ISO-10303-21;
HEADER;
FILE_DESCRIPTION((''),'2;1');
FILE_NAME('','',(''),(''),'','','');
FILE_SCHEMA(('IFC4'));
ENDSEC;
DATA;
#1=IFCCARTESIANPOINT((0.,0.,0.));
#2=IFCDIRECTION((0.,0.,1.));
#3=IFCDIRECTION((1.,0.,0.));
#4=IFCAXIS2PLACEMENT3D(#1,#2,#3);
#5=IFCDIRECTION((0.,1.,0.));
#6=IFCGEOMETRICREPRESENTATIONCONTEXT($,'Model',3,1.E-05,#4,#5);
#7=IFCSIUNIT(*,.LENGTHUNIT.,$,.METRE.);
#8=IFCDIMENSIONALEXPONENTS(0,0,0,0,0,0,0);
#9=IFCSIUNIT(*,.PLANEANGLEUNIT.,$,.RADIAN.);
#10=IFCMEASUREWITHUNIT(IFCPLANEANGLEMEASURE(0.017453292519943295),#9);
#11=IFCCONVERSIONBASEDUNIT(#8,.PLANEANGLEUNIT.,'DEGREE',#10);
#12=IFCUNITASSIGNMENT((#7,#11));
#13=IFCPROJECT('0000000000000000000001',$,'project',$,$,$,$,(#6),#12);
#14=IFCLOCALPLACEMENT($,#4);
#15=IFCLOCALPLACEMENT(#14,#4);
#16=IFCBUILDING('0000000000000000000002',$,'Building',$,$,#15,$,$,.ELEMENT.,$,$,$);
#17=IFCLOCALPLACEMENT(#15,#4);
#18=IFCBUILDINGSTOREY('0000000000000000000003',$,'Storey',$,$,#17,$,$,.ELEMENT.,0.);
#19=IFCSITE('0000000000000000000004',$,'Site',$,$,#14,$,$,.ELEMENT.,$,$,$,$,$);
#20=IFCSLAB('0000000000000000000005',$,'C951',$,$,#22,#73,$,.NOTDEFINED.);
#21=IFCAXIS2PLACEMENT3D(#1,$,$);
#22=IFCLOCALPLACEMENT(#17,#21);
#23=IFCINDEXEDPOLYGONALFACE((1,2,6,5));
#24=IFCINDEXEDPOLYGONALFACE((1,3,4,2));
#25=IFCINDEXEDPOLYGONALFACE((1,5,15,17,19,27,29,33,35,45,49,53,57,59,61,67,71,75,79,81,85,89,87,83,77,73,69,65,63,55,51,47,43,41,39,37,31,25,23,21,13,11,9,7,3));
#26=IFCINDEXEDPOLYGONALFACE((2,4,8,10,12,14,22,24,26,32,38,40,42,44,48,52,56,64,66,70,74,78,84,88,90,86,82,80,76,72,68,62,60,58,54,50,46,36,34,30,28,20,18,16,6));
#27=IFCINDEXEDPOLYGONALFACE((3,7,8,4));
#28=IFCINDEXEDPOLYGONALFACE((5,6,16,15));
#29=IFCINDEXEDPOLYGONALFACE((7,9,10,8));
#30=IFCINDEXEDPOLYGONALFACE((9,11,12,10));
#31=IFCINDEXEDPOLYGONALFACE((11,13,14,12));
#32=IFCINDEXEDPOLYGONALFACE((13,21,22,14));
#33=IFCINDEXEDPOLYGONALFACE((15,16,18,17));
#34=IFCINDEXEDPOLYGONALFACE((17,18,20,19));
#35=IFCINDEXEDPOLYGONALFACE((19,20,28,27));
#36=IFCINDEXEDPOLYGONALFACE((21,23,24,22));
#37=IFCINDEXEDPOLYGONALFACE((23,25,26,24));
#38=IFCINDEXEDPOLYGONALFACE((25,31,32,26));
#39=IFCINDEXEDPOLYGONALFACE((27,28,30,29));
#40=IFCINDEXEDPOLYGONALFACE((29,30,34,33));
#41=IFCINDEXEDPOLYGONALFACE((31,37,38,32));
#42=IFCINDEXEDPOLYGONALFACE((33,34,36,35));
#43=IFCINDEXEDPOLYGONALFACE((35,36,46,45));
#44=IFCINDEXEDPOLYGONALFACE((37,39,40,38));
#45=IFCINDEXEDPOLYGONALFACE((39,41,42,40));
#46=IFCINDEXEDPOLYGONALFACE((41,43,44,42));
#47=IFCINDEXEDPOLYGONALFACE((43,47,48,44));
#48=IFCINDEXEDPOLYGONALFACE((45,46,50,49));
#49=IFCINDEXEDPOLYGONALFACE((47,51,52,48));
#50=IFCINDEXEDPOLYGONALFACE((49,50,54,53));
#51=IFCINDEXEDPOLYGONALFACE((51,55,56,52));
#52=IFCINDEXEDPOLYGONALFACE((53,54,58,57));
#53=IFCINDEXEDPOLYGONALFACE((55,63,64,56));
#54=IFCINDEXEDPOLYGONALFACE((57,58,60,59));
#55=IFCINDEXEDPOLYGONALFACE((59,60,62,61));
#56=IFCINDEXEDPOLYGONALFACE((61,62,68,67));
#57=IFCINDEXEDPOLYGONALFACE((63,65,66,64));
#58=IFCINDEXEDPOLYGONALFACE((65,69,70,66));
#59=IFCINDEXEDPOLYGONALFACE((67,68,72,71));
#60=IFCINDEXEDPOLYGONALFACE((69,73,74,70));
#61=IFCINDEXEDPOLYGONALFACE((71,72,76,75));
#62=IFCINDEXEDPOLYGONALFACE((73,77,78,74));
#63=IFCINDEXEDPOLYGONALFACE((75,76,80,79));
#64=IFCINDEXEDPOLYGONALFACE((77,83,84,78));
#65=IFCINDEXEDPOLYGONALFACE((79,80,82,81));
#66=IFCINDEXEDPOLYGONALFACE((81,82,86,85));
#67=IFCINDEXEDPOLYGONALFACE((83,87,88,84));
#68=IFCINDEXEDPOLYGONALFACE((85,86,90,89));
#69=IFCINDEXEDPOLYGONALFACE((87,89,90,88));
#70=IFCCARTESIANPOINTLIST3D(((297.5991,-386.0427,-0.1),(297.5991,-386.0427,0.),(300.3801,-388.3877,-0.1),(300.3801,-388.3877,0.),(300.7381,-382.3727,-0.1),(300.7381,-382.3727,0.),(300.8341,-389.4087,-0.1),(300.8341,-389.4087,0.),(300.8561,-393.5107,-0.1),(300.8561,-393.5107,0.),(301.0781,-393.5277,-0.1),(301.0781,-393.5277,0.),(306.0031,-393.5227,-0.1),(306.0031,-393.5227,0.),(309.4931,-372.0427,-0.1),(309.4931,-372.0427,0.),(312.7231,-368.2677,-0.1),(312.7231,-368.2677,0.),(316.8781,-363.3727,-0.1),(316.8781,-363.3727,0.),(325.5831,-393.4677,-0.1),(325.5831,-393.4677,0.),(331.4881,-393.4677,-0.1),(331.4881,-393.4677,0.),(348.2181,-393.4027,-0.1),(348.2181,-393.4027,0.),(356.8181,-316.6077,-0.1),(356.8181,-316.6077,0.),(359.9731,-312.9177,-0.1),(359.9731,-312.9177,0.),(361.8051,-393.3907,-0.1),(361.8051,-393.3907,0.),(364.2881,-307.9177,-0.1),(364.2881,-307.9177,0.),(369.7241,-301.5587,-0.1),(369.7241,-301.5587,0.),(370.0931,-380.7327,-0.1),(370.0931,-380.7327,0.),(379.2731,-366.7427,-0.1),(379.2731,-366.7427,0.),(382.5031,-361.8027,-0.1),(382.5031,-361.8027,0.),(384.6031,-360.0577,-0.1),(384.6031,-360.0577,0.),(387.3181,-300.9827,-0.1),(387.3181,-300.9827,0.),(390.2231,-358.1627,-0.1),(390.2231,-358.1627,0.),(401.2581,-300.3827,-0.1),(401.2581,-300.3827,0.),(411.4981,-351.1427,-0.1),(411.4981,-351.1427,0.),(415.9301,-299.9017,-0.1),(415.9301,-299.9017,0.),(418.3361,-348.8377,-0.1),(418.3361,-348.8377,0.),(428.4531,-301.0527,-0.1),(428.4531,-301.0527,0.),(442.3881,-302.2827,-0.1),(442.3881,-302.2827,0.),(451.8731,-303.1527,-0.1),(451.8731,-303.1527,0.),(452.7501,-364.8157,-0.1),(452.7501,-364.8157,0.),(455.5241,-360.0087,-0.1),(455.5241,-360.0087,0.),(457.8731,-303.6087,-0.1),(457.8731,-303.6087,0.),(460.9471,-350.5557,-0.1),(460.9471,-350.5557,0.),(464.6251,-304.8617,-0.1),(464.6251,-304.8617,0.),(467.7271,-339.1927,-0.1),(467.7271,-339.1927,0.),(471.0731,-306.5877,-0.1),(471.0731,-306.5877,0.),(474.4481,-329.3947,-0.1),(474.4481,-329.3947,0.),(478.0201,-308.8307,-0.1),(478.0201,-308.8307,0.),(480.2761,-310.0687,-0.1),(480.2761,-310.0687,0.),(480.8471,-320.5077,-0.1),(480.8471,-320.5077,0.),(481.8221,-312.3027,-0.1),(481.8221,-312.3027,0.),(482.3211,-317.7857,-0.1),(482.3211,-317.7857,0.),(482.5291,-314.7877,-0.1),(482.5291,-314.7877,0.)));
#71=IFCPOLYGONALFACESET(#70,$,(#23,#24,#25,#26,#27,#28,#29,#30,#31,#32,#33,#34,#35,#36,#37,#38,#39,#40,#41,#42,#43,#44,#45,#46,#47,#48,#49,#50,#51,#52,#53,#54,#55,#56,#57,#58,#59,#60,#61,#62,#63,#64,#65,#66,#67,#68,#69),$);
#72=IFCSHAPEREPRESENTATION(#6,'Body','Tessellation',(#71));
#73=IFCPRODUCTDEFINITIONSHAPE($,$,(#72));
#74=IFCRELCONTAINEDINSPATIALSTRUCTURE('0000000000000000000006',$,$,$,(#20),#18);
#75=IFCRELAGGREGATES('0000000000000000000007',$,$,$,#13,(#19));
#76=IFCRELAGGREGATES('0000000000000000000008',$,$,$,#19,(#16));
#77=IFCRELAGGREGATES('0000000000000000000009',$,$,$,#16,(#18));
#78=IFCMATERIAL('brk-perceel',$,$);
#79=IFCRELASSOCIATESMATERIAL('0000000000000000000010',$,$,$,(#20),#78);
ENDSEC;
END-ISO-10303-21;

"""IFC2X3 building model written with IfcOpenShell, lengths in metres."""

from ifc_helpers import new_model, entity, si_unit, converted_unit, direction, frame, origin_with_axes, place, context, project, spatial, polyline, outline, extrude, material, element, save


model = new_model("IFC2X3")

# Units and contexts
model_context = context("Model", 3, precision=1e-05, world=origin_with_axes(), true_north=direction((0.0, 1.0, 0.0)))
ifc_project = project(units=[si_unit("LENGTHUNIT", "METRE"), converted_unit("PLANEANGLEUNIT", "DEGREE", entity("IfcPlaneAngleMeasure", 0.017453292519943295), si_unit("PLANEANGLEUNIT", "RADIAN"), dimensions=[0, 0, 0, 0, 0, 0, 0])], contexts=[model_context])

# Site, building, storey
site_placement = place(None, origin_with_axes())
site = spatial("IfcSite", under=ifc_project, at=site_placement, Name="Site", CompositionType="ELEMENT")
building_placement = place(site_placement, origin_with_axes())
building = spatial("IfcBuilding", under=site, at=building_placement, Name="Building", CompositionType="ELEMENT")
storey_placement = place(building_placement, origin_with_axes())
storey = spatial("IfcBuildingStorey", under=building, at=storey_placement, Name="Storey", CompositionType="ELEMENT", Elevation=0.0)

# Slab
ifc_material = material(Name="brk-perceel")
slab_1_placement = place(storey_placement, frame((0.0, 0.0, -0.1), z_axis=(0.0, 0.0, 1.0), x_axis=(1.0, 0.0, 0.0)))
element("IfcSlab", 1, at=slab_1_placement, inside=storey, material=ifc_material, Name="C951", PredefinedType="NOTDEFINED", context=model_context, shape_type="SweptSolid", body=[
    extrude(outline(polyline([(306.0031, -393.5227), (301.0781, -393.5277), (300.8561, -393.5107), (300.8341, -389.4087), (300.3801, -388.3877), (297.5991, -386.0427), (300.7381, -382.3727), (309.4931, -372.0427), (312.7231, -368.2677), (316.8781, -363.3727), (356.8181, -316.6077), (359.9731, -312.9177), (364.2881, -307.9177), (369.7241, -301.5587), (387.3181, -300.9827), (401.2581, -300.3827), (415.9301, -299.9017), (428.4531, -301.0527), (442.3881, -302.2827), (451.8731, -303.1527), (457.8731, -303.6087), (464.6251, -304.8617), (471.0731, -306.5877), (478.0201, -308.8307), (480.2761, -310.0687), (481.8221, -312.3027), (482.5291, -314.7877), (482.3211, -317.7857), (480.8471, -320.5077), (474.4481, -329.3947), (467.7271, -339.1927), (460.9471, -350.5557), (455.5241, -360.0087), (452.7501, -364.8157), (418.3361, -348.8377), (411.4981, -351.1427), (390.2231, -358.1627), (384.6031, -360.0577), (382.5031, -361.8027), (379.2731, -366.7427), (370.0931, -380.7327), (361.8051, -393.3907), (348.2181, -393.4027), (331.4881, -393.4677), (325.5831, -393.4677), (306.0031, -393.5227)])), origin_with_axes(), (0.0, 0.0, 1.0), 0.1),
])

save(model, "model.ifc")
